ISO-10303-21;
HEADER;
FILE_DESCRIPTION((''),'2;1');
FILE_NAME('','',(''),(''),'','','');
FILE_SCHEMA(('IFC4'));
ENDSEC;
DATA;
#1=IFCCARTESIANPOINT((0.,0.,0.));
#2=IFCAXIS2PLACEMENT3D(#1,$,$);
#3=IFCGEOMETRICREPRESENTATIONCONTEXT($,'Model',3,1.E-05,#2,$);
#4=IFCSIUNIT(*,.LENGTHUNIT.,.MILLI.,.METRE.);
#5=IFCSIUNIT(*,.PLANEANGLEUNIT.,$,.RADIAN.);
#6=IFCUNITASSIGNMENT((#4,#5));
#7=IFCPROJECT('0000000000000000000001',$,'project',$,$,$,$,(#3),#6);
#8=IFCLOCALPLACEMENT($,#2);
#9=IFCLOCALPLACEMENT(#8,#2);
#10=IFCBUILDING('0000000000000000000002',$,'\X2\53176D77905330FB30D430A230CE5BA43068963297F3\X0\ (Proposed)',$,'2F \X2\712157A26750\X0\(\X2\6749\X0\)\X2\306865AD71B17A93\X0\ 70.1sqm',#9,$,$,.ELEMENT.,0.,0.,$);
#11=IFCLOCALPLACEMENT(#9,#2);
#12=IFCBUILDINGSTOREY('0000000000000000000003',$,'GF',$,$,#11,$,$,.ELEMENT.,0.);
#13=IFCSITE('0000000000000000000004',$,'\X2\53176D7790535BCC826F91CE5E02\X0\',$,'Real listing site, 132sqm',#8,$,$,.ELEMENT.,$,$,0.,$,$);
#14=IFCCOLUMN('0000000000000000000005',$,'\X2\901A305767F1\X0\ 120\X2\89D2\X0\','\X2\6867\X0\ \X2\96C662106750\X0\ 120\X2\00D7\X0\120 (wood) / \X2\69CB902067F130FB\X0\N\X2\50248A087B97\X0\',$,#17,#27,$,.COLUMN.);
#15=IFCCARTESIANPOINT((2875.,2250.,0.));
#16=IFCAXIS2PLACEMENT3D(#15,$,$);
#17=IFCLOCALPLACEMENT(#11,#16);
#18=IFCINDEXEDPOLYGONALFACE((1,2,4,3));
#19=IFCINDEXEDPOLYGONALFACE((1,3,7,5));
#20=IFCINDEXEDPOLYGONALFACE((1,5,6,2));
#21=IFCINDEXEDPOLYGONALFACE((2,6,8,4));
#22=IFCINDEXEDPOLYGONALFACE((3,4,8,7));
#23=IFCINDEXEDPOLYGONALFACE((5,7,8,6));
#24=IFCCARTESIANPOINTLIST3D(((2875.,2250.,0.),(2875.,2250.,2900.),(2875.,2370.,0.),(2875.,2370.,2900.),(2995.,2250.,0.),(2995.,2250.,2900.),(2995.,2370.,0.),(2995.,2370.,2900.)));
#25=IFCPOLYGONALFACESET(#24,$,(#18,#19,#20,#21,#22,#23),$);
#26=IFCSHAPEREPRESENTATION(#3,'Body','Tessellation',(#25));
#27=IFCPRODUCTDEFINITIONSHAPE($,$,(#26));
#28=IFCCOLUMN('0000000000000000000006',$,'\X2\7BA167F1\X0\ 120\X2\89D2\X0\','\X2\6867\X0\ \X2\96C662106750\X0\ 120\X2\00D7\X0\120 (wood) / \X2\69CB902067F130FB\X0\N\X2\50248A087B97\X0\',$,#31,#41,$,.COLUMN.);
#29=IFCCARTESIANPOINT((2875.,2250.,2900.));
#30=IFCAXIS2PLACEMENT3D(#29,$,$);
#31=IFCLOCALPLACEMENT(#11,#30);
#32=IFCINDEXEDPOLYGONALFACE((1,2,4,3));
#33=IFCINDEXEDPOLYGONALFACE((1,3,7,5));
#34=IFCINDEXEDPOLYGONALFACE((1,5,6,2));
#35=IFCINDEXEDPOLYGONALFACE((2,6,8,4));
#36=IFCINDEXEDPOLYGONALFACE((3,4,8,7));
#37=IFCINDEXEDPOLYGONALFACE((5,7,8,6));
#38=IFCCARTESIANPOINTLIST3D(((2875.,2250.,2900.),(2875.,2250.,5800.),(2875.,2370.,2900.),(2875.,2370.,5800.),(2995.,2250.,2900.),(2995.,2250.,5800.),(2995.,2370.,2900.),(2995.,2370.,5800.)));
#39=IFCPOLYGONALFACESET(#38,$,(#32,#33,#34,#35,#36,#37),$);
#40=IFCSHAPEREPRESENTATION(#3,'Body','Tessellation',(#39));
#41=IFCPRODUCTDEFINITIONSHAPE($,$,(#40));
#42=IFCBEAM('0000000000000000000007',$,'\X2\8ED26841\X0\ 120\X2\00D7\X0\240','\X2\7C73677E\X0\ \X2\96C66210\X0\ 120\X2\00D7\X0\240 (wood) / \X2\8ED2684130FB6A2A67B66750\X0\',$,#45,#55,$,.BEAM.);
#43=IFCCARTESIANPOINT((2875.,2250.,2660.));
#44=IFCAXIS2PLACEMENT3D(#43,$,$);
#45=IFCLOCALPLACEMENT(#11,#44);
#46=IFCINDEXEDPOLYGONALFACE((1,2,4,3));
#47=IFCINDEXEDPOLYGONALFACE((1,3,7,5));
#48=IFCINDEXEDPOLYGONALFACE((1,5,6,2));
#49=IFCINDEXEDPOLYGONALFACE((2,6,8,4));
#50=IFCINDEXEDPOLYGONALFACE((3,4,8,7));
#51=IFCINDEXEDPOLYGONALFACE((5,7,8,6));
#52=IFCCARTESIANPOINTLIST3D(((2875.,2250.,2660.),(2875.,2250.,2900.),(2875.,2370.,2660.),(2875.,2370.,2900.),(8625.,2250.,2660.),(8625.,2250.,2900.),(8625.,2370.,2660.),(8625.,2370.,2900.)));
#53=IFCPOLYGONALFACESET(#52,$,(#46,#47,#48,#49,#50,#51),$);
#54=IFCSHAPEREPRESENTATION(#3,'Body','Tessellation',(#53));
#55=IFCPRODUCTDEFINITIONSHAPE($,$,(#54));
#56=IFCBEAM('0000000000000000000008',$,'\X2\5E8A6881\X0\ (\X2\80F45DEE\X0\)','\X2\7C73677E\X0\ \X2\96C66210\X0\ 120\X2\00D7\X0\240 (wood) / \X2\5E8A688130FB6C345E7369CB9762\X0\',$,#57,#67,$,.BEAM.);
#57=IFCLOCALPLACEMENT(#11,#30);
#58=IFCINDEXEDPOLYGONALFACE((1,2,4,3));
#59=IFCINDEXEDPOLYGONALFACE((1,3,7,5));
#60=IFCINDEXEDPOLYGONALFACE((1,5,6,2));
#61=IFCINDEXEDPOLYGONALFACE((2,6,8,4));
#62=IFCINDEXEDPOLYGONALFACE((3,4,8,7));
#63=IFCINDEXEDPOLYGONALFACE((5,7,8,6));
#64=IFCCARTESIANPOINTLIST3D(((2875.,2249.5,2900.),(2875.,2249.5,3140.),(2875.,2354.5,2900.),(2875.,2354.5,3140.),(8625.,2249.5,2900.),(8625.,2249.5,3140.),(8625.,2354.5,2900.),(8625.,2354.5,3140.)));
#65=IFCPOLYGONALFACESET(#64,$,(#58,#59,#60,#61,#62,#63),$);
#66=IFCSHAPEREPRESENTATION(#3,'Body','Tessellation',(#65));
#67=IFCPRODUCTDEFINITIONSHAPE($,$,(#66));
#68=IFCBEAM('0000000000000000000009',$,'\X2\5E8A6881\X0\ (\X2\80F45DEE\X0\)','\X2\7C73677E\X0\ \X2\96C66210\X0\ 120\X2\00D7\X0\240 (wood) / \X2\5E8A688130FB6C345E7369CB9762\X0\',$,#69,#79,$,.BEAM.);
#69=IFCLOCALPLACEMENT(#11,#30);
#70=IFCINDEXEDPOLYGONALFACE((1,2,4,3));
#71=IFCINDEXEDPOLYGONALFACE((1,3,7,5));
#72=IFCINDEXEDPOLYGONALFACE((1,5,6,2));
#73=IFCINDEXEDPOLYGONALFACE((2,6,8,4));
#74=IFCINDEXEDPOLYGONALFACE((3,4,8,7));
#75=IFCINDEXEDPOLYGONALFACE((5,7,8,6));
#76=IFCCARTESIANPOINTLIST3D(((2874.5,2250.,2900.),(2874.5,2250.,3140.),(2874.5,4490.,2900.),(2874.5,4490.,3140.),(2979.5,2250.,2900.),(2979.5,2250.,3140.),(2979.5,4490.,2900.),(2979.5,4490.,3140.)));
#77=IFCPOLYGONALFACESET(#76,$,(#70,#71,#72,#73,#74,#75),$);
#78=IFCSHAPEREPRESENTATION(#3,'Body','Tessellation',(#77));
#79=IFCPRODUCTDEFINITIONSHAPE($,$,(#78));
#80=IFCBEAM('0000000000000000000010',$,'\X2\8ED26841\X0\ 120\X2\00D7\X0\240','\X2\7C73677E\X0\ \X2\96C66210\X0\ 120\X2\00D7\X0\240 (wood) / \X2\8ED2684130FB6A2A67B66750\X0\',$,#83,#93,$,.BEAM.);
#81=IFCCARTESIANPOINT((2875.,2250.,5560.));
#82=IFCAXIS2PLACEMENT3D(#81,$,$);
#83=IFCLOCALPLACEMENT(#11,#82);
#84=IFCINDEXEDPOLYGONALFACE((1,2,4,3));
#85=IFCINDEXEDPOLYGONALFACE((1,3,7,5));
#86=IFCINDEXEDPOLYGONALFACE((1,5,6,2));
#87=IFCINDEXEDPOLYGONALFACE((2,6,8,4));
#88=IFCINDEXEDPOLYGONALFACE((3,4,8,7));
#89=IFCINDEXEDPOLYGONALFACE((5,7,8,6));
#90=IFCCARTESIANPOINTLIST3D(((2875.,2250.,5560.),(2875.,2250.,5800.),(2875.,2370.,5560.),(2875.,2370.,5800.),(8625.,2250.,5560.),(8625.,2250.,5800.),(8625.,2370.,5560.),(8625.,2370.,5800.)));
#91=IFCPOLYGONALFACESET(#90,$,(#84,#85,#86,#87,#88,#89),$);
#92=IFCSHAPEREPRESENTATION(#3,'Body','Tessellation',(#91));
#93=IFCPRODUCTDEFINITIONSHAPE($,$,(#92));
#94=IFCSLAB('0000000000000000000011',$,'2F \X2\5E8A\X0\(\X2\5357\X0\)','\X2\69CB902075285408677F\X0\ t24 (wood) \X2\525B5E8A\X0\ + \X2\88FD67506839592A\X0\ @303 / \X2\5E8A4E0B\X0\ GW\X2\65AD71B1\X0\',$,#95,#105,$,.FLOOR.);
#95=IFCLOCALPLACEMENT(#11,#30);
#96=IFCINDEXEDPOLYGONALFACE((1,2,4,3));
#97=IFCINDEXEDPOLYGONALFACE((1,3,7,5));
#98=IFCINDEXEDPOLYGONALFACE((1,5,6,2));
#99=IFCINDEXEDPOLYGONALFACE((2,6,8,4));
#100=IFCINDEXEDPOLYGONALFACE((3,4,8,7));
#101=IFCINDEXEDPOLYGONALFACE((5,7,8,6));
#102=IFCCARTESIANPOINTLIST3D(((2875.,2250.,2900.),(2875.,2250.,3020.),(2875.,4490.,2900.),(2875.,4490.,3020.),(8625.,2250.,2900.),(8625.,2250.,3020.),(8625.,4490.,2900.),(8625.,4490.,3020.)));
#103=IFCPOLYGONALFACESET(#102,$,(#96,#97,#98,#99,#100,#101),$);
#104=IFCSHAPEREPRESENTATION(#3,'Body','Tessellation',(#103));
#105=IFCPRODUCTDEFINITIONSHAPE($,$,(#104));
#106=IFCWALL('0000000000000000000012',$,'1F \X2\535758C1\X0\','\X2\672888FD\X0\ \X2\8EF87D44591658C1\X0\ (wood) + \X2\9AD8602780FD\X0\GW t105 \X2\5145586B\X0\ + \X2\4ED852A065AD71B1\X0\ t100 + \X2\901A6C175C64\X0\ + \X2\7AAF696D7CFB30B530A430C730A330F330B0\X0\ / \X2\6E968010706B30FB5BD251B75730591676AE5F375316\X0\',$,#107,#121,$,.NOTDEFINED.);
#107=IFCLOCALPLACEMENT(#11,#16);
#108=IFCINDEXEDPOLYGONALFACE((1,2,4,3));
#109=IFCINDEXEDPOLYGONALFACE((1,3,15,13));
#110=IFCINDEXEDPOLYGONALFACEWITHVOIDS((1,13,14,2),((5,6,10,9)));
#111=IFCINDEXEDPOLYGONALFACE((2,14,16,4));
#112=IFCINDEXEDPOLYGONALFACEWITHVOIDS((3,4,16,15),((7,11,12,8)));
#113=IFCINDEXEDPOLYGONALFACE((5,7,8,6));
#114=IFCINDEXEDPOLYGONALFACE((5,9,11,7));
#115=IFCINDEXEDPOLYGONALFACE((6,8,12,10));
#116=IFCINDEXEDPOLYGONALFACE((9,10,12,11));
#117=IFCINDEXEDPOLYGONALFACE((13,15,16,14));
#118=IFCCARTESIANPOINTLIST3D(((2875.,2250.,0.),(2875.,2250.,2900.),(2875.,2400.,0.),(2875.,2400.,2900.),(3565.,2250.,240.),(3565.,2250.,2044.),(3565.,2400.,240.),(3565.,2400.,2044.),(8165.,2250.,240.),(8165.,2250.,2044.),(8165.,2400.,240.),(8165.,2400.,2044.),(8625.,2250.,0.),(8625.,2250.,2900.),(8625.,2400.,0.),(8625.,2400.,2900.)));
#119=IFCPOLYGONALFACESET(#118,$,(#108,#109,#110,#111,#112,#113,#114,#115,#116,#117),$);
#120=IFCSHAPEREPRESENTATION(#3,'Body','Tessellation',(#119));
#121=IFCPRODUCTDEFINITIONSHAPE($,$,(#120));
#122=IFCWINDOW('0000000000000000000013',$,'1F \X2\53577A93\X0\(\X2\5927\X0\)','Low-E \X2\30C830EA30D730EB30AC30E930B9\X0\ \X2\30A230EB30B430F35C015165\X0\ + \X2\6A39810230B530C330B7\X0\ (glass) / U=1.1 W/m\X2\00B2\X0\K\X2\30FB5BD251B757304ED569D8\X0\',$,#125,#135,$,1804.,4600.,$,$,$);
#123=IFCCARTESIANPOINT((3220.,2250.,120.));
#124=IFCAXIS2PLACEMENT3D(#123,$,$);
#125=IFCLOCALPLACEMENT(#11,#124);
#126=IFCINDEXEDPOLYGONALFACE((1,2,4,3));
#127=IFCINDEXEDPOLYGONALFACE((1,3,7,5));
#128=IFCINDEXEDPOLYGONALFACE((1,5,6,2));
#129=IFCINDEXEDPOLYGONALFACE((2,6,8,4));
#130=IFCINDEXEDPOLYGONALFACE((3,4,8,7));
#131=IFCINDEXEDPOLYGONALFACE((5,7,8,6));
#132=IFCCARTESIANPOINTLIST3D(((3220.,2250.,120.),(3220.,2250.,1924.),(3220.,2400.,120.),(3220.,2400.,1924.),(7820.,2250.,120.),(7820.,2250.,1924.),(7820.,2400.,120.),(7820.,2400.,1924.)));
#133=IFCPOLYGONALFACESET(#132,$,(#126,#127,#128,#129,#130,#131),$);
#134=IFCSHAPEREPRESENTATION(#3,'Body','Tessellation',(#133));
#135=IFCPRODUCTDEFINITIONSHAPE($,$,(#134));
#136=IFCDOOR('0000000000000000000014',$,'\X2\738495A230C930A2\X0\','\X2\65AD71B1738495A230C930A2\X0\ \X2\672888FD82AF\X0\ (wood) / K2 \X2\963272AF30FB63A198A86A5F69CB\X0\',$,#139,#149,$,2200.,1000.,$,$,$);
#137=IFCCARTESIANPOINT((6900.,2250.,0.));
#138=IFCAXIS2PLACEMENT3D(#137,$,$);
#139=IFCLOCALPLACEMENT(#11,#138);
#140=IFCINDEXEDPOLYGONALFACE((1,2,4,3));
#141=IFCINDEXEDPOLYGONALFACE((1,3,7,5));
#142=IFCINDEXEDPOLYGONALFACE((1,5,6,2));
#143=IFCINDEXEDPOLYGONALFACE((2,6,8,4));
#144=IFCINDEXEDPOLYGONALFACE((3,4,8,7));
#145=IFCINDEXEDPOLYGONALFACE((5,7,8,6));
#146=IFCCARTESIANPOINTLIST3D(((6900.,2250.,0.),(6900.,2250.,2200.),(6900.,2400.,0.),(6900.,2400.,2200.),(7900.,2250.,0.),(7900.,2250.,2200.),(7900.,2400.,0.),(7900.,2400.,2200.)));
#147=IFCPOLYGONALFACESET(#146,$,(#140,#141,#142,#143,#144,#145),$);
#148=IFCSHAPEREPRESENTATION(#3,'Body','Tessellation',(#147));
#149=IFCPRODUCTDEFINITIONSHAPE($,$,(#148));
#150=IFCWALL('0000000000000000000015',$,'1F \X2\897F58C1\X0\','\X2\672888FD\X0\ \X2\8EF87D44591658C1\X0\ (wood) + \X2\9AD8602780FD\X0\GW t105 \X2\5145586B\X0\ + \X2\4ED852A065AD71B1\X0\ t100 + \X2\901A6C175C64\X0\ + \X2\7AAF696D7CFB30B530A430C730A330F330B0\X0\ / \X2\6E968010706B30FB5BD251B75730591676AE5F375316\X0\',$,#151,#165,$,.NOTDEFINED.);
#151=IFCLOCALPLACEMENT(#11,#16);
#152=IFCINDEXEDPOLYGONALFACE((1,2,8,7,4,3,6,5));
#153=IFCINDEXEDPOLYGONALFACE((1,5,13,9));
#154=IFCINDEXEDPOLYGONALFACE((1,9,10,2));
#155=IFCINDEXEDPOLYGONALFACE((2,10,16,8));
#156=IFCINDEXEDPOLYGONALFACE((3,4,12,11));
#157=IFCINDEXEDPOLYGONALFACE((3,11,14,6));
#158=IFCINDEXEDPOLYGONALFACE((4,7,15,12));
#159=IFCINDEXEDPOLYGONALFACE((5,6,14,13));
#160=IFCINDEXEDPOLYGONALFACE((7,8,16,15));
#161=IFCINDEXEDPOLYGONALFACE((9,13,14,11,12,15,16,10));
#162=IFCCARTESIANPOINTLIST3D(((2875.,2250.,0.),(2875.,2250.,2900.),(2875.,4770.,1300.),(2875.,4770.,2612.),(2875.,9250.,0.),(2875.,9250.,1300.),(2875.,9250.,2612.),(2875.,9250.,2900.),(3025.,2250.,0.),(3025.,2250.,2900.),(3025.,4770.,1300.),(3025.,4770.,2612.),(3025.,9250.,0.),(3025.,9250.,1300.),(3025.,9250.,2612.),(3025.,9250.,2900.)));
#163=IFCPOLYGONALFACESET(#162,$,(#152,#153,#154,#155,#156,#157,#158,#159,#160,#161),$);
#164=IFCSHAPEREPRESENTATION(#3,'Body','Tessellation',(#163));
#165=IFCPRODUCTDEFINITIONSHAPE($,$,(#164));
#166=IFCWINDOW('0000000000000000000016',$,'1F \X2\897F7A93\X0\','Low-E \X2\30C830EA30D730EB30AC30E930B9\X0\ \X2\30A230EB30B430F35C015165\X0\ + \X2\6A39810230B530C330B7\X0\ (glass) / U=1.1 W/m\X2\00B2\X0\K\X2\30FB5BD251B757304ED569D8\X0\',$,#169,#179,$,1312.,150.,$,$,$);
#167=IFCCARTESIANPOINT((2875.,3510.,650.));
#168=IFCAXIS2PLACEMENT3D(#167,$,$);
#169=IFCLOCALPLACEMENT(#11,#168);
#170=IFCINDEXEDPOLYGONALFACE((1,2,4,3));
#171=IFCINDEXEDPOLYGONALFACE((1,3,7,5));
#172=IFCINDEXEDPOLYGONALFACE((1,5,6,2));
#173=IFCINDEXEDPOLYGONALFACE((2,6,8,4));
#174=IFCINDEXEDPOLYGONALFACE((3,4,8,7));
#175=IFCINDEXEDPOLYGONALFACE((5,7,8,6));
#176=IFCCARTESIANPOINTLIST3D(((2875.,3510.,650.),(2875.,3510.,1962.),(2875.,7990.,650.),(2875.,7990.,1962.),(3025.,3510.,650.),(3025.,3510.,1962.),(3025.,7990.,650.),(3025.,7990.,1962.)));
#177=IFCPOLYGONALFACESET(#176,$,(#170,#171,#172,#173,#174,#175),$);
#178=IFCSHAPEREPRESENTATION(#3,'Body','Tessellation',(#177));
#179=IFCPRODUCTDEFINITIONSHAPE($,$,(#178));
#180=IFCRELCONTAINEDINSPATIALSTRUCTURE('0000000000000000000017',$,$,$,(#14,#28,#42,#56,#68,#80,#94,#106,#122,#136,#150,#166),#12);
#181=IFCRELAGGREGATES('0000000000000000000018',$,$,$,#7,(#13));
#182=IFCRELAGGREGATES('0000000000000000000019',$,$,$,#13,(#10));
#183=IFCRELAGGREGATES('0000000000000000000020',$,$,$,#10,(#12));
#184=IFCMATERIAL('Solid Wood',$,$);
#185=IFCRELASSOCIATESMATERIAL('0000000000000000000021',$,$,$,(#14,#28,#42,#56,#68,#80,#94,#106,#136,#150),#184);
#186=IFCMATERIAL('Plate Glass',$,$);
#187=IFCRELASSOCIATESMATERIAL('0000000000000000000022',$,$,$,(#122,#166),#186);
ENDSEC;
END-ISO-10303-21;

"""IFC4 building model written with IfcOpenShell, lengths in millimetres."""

from ifc_helpers import new_model, si_unit, frame, frame_2d, origin, place, context, project, spatial, rectangle, extrude, material, element, fill, save


model = new_model("IFC4")

# Units and contexts
model_context = context("Model", 3, precision=1e-05, world=origin())
ifc_project = project(units=[si_unit("LENGTHUNIT", "METRE", prefix="MILLI"), si_unit("PLANEANGLEUNIT", "RADIAN")], contexts=[model_context])

# Site, building, storey
site_placement = place(None, origin())
site = spatial("IfcSite", under=ifc_project, at=site_placement, Name="北海道富良野市", ObjectType="Real listing site, 132sqm", CompositionType="ELEMENT", RefElevation=0.0)
building_placement = place(site_placement, origin())
building = spatial("IfcBuilding", under=site, at=building_placement, Name="北海道・ピアノ室と防音 (Proposed)", ObjectType="2F 無垢材(杉)と断熱窓 70.1sqm", CompositionType="ELEMENT", ElevationOfRefHeight=0.0, ElevationOfTerrain=0.0)
storey_placement = place(building_placement, origin())
storey = spatial("IfcBuildingStorey", under=building, at=storey_placement, Name="GF", CompositionType="ELEMENT", Elevation=0.0)

# Columns
ifc_material_1 = material(Name="Solid Wood")
column_1_placement = place(storey_placement, frame((2875.0, 2250.0, 0.0)))
element("IfcColumn", 1, at=column_1_placement, inside=storey, material=ifc_material_1, Name="通し柱 120角", Description="桧 集成材 120×120 (wood) / 構造柱・N値計算", PredefinedType="COLUMN", context=model_context, shape_type="SweptSolid", body=[
    extrude(rectangle(XDim=120.0, YDim=120.0, at=frame_2d((60.0, 60.0))), frame((2875.0, 2250.0, 0.0)), (0.0, 0.0, 1.0), 2900.0),
])
column_2_placement = place(storey_placement, frame((2875.0, 2250.0, 2900.0)))
element("IfcColumn", 2, at=column_2_placement, inside=storey, material=ifc_material_1, Name="管柱 120角", Description="桧 集成材 120×120 (wood) / 構造柱・N値計算", PredefinedType="COLUMN", context=model_context, shape_type="SweptSolid", body=[
    extrude(rectangle(XDim=120.0, YDim=120.0, at=frame_2d((60.0, 60.0))), frame((2875.0, 2250.0, 2900.0)), (0.0, 0.0, 1.0), 2900.0),
])

# Beams
beam_1_placement = place(storey_placement, frame((2875.0, 2250.0, 2660.0)))
element("IfcBeam", 3, at=beam_1_placement, inside=storey, material=ifc_material_1, Name="軒桁 120×240", Description="米松 集成 120×240 (wood) / 軒桁・横架材", PredefinedType="BEAM", context=model_context, shape_type="SweptSolid", body=[
    extrude(rectangle(XDim=5750.0, YDim=120.0, at=frame_2d((2875.0, 60.0))), frame((2875.0, 2250.0, 2660.0)), (0.0, 0.0, 1.0), 240.0),
])
beam_2_placement = place(storey_placement, frame((2875.0, 2250.0, 2900.0)))
element("IfcBeam", 4, at=beam_2_placement, inside=storey, material=ifc_material_1, Name="床梁 (胴差)", Description="米松 集成 120×240 (wood) / 床梁・水平構面", PredefinedType="BEAM", context=model_context, shape_type="SweptSolid", body=[
    extrude(rectangle(XDim=5750.0, YDim=105.0, at=frame_2d((2875.0, 52.0))), frame((2875.0, 2250.0, 2900.0)), (0.0, 0.0, 1.0), 240.0),
])
beam_3_placement = place(storey_placement, frame((2875.0, 2250.0, 2900.0)))
element("IfcBeam", 5, at=beam_3_placement, inside=storey, material=ifc_material_1, Name="床梁 (胴差)", Description="米松 集成 120×240 (wood) / 床梁・水平構面", PredefinedType="BEAM", context=model_context, shape_type="SweptSolid", body=[
    extrude(rectangle(XDim=105.0, YDim=2240.0, at=frame_2d((52.0, 1120.0))), frame((2875.0, 2250.0, 2900.0)), (0.0, 0.0, 1.0), 240.0),
])
beam_4_placement = place(storey_placement, frame((2875.0, 2250.0, 5560.0)))
element("IfcBeam", 6, at=beam_4_placement, inside=storey, material=ifc_material_1, Name="軒桁 120×240", Description="米松 集成 120×240 (wood) / 軒桁・横架材", PredefinedType="BEAM", context=model_context, shape_type="SweptSolid", body=[
    extrude(rectangle(XDim=5750.0, YDim=120.0, at=frame_2d((2875.0, 60.0))), frame((2875.0, 2250.0, 5560.0)), (0.0, 0.0, 1.0), 240.0),
])

# Slab
slab_1_placement = place(storey_placement, frame((2875.0, 2250.0, 2900.0)))
element("IfcSlab", 7, at=slab_1_placement, inside=storey, material=ifc_material_1, Name="2F 床(南)", Description="構造用合板 t24 (wood) 剛床 + 製材根太 @303 / 床下 GW断熱", PredefinedType="FLOOR", context=model_context, shape_type="SweptSolid", body=[
    extrude(rectangle(XDim=5750.0, YDim=2240.0, at=frame_2d((2875.0, 1120.0))), frame((2875.0, 2250.0, 2900.0)), (0.0, 0.0, 1.0), 120.0),
])

# Wall, openings, window, door
wall_1_placement = place(storey_placement, frame((2875.0, 2250.0, 0.0)))
wall_1 = element("IfcWall", 8, at=wall_1_placement, inside=storey, material=ifc_material_1, Name="1F 南壁", Description="木製 軸組外壁 (wood) + 高性能GW t105 充填 + 付加断熱 t100 + 通気層 + 窯業系サイディング / 準耐火・寒冷地外皮強化", PredefinedType="NOTDEFINED", context=model_context, shape_type="SweptSolid", body=[
    extrude(rectangle(XDim=5750.0, YDim=150.0, at=frame_2d((2875.0, 75.0))), frame((2875.0, 2250.0, 0.0)), (0.0, 0.0, 1.0), 2900.0),
])
opening_1_placement = place(storey_placement, frame((3220.0, 2250.0, 120.0)))
opening_1 = element("IfcOpeningElement", 9, at=opening_1_placement, cuts=wall_1, PredefinedType="NOTDEFINED", context=model_context, shape_type="SweptSolid", body=[
    extrude(rectangle(XDim=4600.0, YDim=150.0, at=frame_2d((2300.0, 75.0))), frame((3220.0, 2250.0, 120.0)), (0.0, 0.0, 1.0), 1804.0),
])
opening_2_placement = place(storey_placement, frame((6900.0, 2250.0, 0.0)))
opening_2 = element("IfcOpeningElement", 10, at=opening_2_placement, cuts=wall_1, PredefinedType="NOTDEFINED", context=model_context, shape_type="SweptSolid", body=[
    extrude(rectangle(XDim=1000.0, YDim=150.0, at=frame_2d((500.0, 75.0))), frame((6900.0, 2250.0, 0.0)), (0.0, 0.0, 1.0), 2200.0),
])
ifc_material_2 = material(Name="Plate Glass")
window_1_placement = place(storey_placement, frame((3220.0, 2250.0, 120.0)))
window_1 = element("IfcWindow", 11, at=window_1_placement, inside=storey, material=ifc_material_2, Name="1F 南窓(大)", Description="Low-E トリプルガラス アルゴン封入 + 樹脂サッシ (glass) / U=1.1 W/m²K・寒冷地仕様", OverallHeight=1804.0, OverallWidth=4600.0, context=model_context, shape_type="SweptSolid", body=[
    extrude(rectangle(XDim=4600.0, YDim=150.0, at=frame_2d((2300.0, 75.0))), frame((3220.0, 2250.0, 120.0)), (0.0, 0.0, 1.0), 1804.0),
])
fill(opening_1, window_1)
door_placement = place(storey_placement, frame((6900.0, 2250.0, 0.0)))
door = element("IfcDoor", 12, at=door_placement, inside=storey, material=ifc_material_1, Name="玄関ドア", Description="断熱玄関ドア 木製芯 (wood) / K2 防犯・採風機構", OverallHeight=2200.0, OverallWidth=1000.0, context=model_context, shape_type="SweptSolid", body=[
    extrude(rectangle(XDim=1000.0, YDim=150.0, at=frame_2d((500.0, 75.0))), frame((6900.0, 2250.0, 0.0)), (0.0, 0.0, 1.0), 2200.0),
])
fill(opening_2, door)

# Wall, opening, window
wall_2_placement = place(storey_placement, frame((2875.0, 2250.0, 0.0)))
wall_2 = element("IfcWall", 13, at=wall_2_placement, inside=storey, material=ifc_material_1, Name="1F 西壁", Description="木製 軸組外壁 (wood) + 高性能GW t105 充填 + 付加断熱 t100 + 通気層 + 窯業系サイディング / 準耐火・寒冷地外皮強化", PredefinedType="NOTDEFINED", context=model_context, shape_type="SweptSolid", body=[
    extrude(rectangle(XDim=150.0, YDim=7000.0, at=frame_2d((75.0, 3500.0))), frame((2875.0, 2250.0, 0.0)), (0.0, 0.0, 1.0), 2900.0),
])
opening_3_placement = place(storey_placement, frame((2875.0, 3510.0, 650.0)))
opening_3 = element("IfcOpeningElement", 14, at=opening_3_placement, cuts=wall_2, PredefinedType="NOTDEFINED", context=model_context, shape_type="SweptSolid", body=[
    extrude(rectangle(XDim=150.0, YDim=4480.0, at=frame_2d((75.0, 2240.0))), frame((2875.0, 3510.0, 650.0)), (0.0, 0.0, 1.0), 1312.0),
])
window_2_placement = place(storey_placement, frame((2875.0, 3510.0, 650.0)))
window_2 = element("IfcWindow", 15, at=window_2_placement, inside=storey, material=ifc_material_2, Name="1F 西窓", Description="Low-E トリプルガラス アルゴン封入 + 樹脂サッシ (glass) / U=1.1 W/m²K・寒冷地仕様", OverallHeight=1312.0, OverallWidth=150.0, context=model_context, shape_type="SweptSolid", body=[
    extrude(rectangle(XDim=150.0, YDim=4480.0, at=frame_2d((75.0, 2240.0))), frame((2875.0, 3510.0, 650.0)), (0.0, 0.0, 1.0), 1312.0),
])
fill(opening_3, window_2)

save(model, "model.ifc")
